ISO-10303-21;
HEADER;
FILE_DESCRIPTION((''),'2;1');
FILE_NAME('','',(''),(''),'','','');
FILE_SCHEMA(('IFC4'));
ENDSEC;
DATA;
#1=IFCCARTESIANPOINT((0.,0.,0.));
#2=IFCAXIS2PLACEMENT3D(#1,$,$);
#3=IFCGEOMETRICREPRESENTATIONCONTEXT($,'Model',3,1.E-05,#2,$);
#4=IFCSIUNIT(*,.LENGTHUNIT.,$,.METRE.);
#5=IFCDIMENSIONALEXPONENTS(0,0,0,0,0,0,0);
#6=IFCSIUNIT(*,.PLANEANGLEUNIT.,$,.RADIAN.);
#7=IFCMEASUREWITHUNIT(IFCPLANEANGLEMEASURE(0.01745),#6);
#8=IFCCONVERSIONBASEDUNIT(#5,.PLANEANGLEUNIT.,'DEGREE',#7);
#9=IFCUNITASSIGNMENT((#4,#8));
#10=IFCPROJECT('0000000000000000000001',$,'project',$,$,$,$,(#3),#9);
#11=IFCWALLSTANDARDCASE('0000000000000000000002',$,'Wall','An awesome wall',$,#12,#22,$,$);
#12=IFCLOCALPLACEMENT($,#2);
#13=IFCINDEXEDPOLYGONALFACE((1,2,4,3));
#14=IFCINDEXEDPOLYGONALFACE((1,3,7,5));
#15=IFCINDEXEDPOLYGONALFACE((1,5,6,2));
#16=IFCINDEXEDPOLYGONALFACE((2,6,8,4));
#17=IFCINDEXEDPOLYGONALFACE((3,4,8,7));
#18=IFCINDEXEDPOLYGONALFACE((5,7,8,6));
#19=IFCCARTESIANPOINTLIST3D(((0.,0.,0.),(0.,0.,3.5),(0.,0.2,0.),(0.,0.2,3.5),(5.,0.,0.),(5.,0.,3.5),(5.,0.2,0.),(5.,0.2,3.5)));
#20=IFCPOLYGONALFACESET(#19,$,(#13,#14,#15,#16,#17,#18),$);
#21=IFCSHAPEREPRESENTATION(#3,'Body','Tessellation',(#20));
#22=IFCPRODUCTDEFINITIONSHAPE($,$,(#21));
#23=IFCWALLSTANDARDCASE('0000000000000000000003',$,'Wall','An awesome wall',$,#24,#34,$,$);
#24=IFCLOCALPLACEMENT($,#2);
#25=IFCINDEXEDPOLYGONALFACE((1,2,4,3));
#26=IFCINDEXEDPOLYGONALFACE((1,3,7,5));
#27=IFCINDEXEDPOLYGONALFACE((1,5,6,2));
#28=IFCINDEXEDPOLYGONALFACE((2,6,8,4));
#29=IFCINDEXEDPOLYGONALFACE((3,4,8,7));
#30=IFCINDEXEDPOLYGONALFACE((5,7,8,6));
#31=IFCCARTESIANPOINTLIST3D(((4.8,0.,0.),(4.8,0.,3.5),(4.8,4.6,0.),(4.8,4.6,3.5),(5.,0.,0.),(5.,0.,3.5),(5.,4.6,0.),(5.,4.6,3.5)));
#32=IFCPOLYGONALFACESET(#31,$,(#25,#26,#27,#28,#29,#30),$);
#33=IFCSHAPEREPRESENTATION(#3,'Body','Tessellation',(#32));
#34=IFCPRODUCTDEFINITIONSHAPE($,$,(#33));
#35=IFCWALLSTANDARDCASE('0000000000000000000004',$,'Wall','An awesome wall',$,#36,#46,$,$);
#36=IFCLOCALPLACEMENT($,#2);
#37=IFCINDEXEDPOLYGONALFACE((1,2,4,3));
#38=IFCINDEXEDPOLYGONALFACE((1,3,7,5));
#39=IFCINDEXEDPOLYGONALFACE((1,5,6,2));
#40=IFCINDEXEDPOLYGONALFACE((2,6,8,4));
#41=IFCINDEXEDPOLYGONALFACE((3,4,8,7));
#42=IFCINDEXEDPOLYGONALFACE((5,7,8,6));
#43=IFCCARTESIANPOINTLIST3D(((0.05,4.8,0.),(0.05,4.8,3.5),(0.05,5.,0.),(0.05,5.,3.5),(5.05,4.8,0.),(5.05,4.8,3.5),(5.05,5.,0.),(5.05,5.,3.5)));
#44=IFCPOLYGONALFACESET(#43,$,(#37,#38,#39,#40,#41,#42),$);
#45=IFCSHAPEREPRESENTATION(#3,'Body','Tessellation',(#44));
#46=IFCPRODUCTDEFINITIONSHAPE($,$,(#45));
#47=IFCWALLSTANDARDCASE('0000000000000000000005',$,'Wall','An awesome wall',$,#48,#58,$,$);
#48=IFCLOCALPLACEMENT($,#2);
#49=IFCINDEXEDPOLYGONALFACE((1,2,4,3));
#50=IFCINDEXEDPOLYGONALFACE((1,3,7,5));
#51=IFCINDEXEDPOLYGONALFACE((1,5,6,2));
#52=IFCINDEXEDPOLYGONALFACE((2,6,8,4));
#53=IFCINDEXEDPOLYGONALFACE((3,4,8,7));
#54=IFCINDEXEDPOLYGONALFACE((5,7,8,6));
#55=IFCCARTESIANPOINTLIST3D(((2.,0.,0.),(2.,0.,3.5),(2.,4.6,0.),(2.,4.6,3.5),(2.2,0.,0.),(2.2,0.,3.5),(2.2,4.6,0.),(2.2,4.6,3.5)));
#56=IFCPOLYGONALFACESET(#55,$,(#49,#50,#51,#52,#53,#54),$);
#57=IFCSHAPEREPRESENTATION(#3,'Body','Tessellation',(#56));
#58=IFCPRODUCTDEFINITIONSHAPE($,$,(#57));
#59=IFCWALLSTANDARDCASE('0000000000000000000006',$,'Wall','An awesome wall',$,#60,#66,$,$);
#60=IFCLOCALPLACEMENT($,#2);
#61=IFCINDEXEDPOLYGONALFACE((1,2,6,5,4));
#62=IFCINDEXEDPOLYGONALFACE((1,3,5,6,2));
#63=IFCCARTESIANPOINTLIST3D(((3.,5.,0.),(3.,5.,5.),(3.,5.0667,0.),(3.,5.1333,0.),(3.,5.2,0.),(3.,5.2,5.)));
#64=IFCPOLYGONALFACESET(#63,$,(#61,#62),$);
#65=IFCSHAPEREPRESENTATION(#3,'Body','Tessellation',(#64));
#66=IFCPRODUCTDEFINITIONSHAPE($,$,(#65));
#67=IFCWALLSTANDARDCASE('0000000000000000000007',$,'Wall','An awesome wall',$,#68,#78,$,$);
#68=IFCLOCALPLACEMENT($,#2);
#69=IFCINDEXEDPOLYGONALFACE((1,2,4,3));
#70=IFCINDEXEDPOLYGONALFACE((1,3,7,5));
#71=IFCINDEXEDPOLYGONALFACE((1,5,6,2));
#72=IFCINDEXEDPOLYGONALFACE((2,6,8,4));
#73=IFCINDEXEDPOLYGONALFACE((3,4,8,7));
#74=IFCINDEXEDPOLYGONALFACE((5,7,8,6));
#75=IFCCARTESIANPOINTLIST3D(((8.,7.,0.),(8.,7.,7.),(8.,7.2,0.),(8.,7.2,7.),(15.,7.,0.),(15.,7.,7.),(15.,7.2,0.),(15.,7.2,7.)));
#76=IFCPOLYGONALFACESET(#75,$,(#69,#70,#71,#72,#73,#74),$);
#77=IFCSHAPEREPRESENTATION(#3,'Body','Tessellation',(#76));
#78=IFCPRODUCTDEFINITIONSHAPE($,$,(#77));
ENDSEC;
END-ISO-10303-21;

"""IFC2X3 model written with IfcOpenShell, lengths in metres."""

from ifc_helpers import new_model, entity, si_unit, converted_unit, origin, origin_with_axes, place, context, project, polyline, outline, extrude, element, save


model = new_model("IFC2X3")

# Units and contexts
model_context = context("Model", 3, precision=1e-05, world=origin())
ifc_project = project(units=[si_unit("LENGTHUNIT", "METRE"), converted_unit("PLANEANGLEUNIT", "DEGREE", entity("IfcPlaneAngleMeasure", 0.01745), si_unit("PLANEANGLEUNIT", "RADIAN"), dimensions=[0, 0, 0, 0, 0, 0, 0])], contexts=[model_context])

# Walls
placement_1 = place(None, origin_with_axes())
placement_2 = place(placement_1, origin_with_axes())
placement_3 = place(placement_2, origin_with_axes())
wall_1_placement = place(placement_3, origin_with_axes())
element("IfcWallStandardCase", 1, at=wall_1_placement, Name="Wall", Description="An awesome wall", context=model_context, shape_type="SweptSolid", body=[
    extrude(outline(polyline([(0.0, 0.0, 0.0), (5.0, 0.0, 0.0), (5.0, 0.2, 0.0), (0.0, 0.2, 0.0), (0.0, 0.0, 0.0)])), origin_with_axes(), (0.0, 0.0, 1.0), 3.5),
])
placement_4 = place(None, origin_with_axes())
placement_5 = place(placement_4, origin_with_axes())
placement_6 = place(placement_5, origin_with_axes())
wall_2_placement = place(placement_6, origin_with_axes())
element("IfcWallStandardCase", 2, at=wall_2_placement, Name="Wall", Description="An awesome wall", context=model_context, shape_type="SweptSolid", body=[
    extrude(outline(polyline([(4.8, 0.0, 0.0), (5.0, 0.0, 0.0), (5.0, 4.6, 0.0), (4.8, 4.6, 0.0), (4.8, 0.0, 0.0)])), origin_with_axes(), (0.0, 0.0, 1.0), 3.5),
])
placement_7 = place(None, origin_with_axes())
placement_8 = place(placement_7, origin_with_axes())
placement_9 = place(placement_8, origin_with_axes())
wall_3_placement = place(placement_9, origin_with_axes())
element("IfcWallStandardCase", 3, at=wall_3_placement, Name="Wall", Description="An awesome wall", context=model_context, shape_type="SweptSolid", body=[
    extrude(outline(polyline([(0.05, 4.8, 0.0), (5.05, 4.8, 0.0), (5.05, 5.0, 0.0), (0.05, 5.0, 0.0), (0.05, 4.8, 0.0)])), origin_with_axes(), (0.0, 0.0, 1.0), 3.5),
])
placement_10 = place(None, origin_with_axes())
placement_11 = place(placement_10, origin_with_axes())
placement_12 = place(placement_11, origin_with_axes())
wall_4_placement = place(placement_12, origin_with_axes())
element("IfcWallStandardCase", 4, at=wall_4_placement, Name="Wall", Description="An awesome wall", context=model_context, shape_type="SweptSolid", body=[
    extrude(outline(polyline([(2.0, 0.0, 0.0), (2.2, 0.0, 0.0), (2.2, 4.6, 0.0), (2.0, 4.6, 0.0), (2.0, 0.0, 0.0)])), origin_with_axes(), (0.0, 0.0, 1.0), 3.5),
])
placement_13 = place(None, origin_with_axes())
placement_14 = place(placement_13, origin_with_axes())
placement_15 = place(placement_14, origin_with_axes())
wall_5_placement = place(placement_15, origin_with_axes())
element("IfcWallStandardCase", 5, at=wall_5_placement, Name="Wall", Description="An awesome wall", context=model_context, shape_type="SweptSolid", body=[
    extrude(outline(polyline([(3.0, 5.0, 0.0), (3.0, 5.0, 0.0), (3.0, 5.2, 0.0), (3.0, 5.2, 0.0), (3.0, 5.0, 0.0)])), origin_with_axes(), (0.0, 0.0, 1.0), 5.0),
])
placement_16 = place(None, origin_with_axes())
placement_17 = place(placement_16, origin_with_axes())
placement_18 = place(placement_17, origin_with_axes())
wall_6_placement = place(placement_18, origin_with_axes())
element("IfcWallStandardCase", 6, at=wall_6_placement, Name="Wall", Description="An awesome wall", context=model_context, shape_type="SweptSolid", body=[
    extrude(outline(polyline([(8.0, 7.0, 0.0), (15.0, 7.0, 0.0), (15.0, 7.2, 0.0), (8.0, 7.2, 0.0), (8.0, 7.0, 0.0)])), origin_with_axes(), (0.0, 0.0, 1.0), 7.0),
])

save(model, "model.ifc")
